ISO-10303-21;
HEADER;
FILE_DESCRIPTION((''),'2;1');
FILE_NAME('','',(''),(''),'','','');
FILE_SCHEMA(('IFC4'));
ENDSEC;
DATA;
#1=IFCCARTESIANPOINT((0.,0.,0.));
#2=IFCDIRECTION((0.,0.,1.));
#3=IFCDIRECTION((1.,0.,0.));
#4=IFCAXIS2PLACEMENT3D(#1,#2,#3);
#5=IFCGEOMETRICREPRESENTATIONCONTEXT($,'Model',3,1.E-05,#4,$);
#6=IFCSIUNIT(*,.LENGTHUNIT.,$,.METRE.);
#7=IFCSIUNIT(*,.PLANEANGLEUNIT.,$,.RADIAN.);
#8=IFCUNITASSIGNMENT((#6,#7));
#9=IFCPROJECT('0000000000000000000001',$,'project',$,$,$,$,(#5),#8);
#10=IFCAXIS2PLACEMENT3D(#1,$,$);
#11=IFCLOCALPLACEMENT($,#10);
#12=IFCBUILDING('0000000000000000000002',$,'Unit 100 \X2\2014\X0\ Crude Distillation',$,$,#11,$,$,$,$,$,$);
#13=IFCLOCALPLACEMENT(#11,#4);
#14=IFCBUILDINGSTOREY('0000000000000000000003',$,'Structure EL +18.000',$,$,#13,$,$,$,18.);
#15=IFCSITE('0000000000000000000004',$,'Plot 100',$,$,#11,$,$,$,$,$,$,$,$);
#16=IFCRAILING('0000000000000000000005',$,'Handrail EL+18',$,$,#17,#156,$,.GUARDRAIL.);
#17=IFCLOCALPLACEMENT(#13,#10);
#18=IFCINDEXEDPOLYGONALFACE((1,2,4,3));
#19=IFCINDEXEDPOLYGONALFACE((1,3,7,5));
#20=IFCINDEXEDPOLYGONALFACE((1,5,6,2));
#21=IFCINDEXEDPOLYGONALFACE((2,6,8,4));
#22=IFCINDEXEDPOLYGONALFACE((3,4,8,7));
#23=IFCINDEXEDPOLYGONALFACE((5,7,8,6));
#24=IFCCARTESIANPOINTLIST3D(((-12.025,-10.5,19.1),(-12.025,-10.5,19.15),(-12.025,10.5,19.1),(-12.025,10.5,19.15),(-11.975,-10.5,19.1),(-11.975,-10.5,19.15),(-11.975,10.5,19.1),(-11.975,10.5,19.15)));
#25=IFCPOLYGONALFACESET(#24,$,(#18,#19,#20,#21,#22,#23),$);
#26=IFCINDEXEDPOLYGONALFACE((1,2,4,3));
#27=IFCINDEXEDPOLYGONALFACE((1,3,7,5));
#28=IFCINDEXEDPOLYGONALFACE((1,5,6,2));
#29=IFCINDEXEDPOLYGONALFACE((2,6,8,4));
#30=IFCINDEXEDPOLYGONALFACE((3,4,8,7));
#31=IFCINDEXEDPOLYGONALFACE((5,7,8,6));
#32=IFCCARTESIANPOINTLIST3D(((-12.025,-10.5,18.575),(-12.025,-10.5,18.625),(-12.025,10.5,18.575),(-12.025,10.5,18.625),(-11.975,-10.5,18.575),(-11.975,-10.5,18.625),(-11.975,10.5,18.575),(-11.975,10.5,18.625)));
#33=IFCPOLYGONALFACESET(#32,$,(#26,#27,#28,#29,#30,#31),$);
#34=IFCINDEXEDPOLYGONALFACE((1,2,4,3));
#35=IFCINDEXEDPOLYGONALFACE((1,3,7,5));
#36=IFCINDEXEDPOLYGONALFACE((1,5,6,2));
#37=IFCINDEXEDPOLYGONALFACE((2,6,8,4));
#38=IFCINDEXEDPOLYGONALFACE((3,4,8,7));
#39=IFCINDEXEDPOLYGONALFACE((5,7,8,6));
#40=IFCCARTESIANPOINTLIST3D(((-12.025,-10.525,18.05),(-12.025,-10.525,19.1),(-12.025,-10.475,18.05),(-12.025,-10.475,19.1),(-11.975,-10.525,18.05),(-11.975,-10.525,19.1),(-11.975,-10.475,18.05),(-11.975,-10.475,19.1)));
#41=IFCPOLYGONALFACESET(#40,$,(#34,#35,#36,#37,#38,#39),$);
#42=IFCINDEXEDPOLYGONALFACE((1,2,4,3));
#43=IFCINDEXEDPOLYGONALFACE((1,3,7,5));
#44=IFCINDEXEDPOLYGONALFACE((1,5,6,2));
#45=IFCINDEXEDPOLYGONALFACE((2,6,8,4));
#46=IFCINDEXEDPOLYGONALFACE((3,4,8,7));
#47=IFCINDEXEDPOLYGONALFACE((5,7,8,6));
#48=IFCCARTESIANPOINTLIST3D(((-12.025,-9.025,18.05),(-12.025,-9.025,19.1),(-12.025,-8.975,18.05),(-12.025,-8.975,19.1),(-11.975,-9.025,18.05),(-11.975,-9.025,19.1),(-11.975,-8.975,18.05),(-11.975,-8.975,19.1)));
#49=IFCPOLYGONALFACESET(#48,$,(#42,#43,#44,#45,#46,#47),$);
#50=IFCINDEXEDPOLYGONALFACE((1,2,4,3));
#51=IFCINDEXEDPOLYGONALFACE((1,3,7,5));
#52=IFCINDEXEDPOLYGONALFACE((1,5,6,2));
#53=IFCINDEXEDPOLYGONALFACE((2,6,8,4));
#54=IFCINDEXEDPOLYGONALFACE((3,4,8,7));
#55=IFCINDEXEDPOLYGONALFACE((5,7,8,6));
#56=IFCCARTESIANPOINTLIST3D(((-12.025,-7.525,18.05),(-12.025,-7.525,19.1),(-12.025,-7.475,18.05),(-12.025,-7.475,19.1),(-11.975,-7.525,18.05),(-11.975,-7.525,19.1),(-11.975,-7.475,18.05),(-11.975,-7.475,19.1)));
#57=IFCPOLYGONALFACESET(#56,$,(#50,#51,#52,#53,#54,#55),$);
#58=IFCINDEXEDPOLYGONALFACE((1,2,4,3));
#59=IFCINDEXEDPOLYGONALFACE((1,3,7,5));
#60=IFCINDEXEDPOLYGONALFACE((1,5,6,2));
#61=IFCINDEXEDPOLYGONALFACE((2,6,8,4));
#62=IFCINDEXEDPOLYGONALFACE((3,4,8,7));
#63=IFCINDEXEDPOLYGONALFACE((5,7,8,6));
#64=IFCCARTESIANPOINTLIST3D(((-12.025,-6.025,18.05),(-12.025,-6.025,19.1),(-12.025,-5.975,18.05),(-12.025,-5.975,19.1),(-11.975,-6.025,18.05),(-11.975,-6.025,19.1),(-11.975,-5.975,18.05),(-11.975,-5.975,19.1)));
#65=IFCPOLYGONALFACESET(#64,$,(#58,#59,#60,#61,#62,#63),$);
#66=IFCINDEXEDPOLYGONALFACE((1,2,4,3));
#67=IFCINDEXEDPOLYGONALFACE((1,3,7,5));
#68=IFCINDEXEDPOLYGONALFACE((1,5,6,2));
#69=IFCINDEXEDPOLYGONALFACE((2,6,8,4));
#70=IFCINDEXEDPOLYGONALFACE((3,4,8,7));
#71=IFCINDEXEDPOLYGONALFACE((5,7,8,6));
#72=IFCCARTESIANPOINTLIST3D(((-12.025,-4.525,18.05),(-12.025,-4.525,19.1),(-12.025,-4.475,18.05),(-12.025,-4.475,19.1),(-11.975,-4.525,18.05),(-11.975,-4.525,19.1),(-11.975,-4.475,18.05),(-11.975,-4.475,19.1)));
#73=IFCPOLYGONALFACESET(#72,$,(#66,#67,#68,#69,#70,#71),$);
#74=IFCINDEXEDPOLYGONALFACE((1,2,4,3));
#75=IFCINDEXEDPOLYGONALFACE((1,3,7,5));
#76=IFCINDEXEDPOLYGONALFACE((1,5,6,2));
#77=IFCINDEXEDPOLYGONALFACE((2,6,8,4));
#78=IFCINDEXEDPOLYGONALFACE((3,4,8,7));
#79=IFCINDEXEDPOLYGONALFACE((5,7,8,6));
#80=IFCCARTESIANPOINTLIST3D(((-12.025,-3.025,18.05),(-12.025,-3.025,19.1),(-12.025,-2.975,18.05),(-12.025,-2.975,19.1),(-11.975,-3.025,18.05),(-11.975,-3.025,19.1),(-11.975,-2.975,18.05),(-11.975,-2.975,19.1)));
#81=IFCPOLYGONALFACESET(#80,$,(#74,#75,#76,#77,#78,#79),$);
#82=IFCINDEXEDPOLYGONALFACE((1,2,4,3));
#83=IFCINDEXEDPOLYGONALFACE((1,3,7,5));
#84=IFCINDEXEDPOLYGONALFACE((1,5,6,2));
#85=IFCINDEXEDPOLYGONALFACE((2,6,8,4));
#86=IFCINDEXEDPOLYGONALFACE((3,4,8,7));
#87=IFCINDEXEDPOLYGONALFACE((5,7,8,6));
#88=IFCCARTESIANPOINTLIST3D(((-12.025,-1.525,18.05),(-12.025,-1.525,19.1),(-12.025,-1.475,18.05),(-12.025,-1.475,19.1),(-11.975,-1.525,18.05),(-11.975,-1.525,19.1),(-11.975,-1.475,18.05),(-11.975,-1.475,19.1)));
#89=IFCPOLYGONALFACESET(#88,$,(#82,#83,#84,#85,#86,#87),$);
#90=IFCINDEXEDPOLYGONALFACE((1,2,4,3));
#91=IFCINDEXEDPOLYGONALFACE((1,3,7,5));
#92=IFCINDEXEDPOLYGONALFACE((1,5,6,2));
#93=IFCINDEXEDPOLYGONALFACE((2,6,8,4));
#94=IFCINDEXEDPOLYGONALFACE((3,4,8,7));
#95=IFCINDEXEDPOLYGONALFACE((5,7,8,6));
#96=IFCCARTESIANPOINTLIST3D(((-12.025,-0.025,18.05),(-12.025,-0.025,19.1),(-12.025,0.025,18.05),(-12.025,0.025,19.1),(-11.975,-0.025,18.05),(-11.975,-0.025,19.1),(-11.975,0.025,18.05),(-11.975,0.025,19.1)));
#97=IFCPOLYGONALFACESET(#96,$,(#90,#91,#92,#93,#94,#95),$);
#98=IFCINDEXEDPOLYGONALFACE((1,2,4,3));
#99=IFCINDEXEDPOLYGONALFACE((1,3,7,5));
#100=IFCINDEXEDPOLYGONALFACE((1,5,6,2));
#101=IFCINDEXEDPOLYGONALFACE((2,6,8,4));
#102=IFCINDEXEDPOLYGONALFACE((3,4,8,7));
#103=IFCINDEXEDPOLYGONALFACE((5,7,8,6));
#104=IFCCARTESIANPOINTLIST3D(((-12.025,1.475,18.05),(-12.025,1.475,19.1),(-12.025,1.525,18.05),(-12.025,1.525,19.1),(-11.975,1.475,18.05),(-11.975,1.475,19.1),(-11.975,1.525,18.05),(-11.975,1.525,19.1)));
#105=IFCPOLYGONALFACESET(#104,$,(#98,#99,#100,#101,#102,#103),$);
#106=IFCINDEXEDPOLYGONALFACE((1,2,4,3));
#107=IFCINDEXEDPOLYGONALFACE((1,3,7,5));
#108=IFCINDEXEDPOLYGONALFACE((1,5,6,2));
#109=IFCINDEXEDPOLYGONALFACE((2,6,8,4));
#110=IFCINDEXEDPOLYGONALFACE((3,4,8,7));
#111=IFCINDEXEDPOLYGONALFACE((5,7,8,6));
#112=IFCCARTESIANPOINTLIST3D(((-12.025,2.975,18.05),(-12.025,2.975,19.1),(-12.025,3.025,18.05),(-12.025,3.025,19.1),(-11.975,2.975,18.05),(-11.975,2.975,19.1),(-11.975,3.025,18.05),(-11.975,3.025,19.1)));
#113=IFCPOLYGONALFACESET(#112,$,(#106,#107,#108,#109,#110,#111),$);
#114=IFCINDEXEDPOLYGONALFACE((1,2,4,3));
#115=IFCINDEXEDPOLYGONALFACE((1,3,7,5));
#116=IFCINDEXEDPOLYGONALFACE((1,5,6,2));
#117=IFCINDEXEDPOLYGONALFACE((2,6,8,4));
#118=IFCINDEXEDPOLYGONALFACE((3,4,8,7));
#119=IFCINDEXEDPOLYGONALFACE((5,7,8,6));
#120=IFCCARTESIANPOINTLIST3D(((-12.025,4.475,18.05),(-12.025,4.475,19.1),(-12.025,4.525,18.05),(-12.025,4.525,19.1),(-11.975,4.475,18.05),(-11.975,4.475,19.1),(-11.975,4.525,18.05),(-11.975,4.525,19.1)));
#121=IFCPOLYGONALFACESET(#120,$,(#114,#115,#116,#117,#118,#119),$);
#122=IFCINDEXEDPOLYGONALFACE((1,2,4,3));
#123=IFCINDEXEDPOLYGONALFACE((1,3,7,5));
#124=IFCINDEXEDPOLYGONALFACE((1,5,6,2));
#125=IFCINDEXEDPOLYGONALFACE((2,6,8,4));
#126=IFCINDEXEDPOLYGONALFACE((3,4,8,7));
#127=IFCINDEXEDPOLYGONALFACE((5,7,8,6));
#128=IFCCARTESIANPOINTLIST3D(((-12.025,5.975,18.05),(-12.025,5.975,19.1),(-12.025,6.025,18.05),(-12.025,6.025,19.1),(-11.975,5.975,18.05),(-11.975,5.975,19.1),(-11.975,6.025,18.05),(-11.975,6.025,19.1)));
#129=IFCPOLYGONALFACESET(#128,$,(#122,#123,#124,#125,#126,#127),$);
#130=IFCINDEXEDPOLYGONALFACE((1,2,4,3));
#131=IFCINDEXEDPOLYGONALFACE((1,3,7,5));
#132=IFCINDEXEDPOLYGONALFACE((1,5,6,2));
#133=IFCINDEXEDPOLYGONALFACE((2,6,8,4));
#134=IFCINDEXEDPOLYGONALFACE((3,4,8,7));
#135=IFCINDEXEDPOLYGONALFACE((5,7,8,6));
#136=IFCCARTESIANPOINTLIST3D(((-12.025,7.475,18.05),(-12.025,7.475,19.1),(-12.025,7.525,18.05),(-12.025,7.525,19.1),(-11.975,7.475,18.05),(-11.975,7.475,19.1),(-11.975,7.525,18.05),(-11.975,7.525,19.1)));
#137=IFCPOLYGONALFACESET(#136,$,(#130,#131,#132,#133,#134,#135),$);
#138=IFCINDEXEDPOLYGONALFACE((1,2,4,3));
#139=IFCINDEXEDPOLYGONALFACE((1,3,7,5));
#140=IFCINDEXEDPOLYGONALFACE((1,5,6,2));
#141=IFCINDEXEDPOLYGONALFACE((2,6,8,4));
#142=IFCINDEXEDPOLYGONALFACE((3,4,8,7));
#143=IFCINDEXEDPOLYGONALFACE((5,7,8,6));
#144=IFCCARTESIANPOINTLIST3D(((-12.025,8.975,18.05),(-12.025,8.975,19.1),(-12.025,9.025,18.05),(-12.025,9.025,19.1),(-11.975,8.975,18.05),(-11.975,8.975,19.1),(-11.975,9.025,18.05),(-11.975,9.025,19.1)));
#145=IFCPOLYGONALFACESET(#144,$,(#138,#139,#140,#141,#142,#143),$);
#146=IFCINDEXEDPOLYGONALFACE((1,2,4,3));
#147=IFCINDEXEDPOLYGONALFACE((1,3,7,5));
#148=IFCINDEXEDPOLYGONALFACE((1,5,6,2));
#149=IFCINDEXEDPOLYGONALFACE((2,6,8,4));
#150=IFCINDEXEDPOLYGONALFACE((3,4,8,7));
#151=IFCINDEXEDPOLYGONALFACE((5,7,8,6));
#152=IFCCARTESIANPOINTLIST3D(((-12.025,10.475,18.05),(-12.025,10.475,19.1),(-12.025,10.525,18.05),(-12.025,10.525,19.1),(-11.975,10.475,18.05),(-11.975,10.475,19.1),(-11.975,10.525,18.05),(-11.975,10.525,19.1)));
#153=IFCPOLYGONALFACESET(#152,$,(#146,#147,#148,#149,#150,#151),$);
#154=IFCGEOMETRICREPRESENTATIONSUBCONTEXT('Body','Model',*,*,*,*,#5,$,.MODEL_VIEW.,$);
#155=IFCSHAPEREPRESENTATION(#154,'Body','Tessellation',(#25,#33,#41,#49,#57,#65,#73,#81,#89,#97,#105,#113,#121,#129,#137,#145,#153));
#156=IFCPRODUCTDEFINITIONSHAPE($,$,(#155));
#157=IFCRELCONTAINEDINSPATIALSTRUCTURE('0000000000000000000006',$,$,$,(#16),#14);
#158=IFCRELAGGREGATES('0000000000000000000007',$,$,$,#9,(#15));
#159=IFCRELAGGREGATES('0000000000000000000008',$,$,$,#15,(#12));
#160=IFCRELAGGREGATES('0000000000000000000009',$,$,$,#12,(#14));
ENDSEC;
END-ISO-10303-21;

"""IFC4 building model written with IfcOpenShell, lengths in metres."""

from ifc_helpers import new_model, si_unit, frame, origin, origin_with_axes, origin_2d, place, context, subcontext, project, spatial, rectangle, extrude, element, save


model = new_model("IFC4")

# Units and contexts
model_context = context("Model", 3, precision=1e-05, world=origin_with_axes())
body_context = subcontext(model_context, "Body", "Model", "MODEL_VIEW")
ifc_project = project(units=[si_unit("LENGTHUNIT", "METRE"), si_unit("PLANEANGLEUNIT", "RADIAN")], contexts=[model_context])

# Site, building, storey
placement = place(None, origin())
site = spatial("IfcSite", under=ifc_project, at=placement, Name="Plot 100")
building = spatial("IfcBuilding", under=site, at=placement, Name="Unit 100 — Crude Distillation")
storey_placement = place(placement, origin_with_axes())
storey = spatial("IfcBuildingStorey", under=building, at=storey_placement, Name="Structure EL +18.000", Elevation=18.0)

# Railing
railing_1_placement = place(storey_placement, origin_with_axes())
element("IfcRailing", 1, at=railing_1_placement, inside=storey, Name="Handrail EL+18", PredefinedType="GUARDRAIL", context=body_context, shape_type="SweptSolid", body=[
    extrude(rectangle(XDim=0.05, YDim=0.05, at=origin_2d()), frame((-12.0, -10.5, 19.125), z_axis=(0.0, 1.0, 0.0), x_axis=(-1.0, 0.0, 0.0)), (0.0, 0.0, 1.0), 21.0),
    extrude(rectangle(XDim=0.05, YDim=0.05, at=origin_2d()), frame((-12.0, -10.5, 18.6), z_axis=(0.0, 1.0, 0.0), x_axis=(-1.0, 0.0, 0.0)), (0.0, 0.0, 1.0), 21.0),
    extrude(rectangle(XDim=0.05, YDim=0.05, at=origin_2d()), frame((-12.0, -10.5, 18.05), z_axis=(0.0, 0.0, 1.0), x_axis=(1.0, 0.0, 0.0)), (0.0, 0.0, 1.0), 1.05),
    extrude(rectangle(XDim=0.05, YDim=0.05, at=origin_2d()), frame((-12.0, -9.0, 18.05), z_axis=(0.0, 0.0, 1.0), x_axis=(1.0, 0.0, 0.0)), (0.0, 0.0, 1.0), 1.05),
    extrude(rectangle(XDim=0.05, YDim=0.05, at=origin_2d()), frame((-12.0, -7.5, 18.05), z_axis=(0.0, 0.0, 1.0), x_axis=(1.0, 0.0, 0.0)), (0.0, 0.0, 1.0), 1.05),
    extrude(rectangle(XDim=0.05, YDim=0.05, at=origin_2d()), frame((-12.0, -6.0, 18.05), z_axis=(0.0, 0.0, 1.0), x_axis=(1.0, 0.0, 0.0)), (0.0, 0.0, 1.0), 1.05),
    extrude(rectangle(XDim=0.05, YDim=0.05, at=origin_2d()), frame((-12.0, -4.5, 18.05), z_axis=(0.0, 0.0, 1.0), x_axis=(1.0, 0.0, 0.0)), (0.0, 0.0, 1.0), 1.05),
    extrude(rectangle(XDim=0.05, YDim=0.05, at=origin_2d()), frame((-12.0, -3.0, 18.05), z_axis=(0.0, 0.0, 1.0), x_axis=(1.0, 0.0, 0.0)), (0.0, 0.0, 1.0), 1.05),
    extrude(rectangle(XDim=0.05, YDim=0.05, at=origin_2d()), frame((-12.0, -1.5, 18.05), z_axis=(0.0, 0.0, 1.0), x_axis=(1.0, 0.0, 0.0)), (0.0, 0.0, 1.0), 1.05),
    extrude(rectangle(XDim=0.05, YDim=0.05, at=origin_2d()), frame((-12.0, 0.0, 18.05), z_axis=(0.0, 0.0, 1.0), x_axis=(1.0, 0.0, 0.0)), (0.0, 0.0, 1.0), 1.05),
    extrude(rectangle(XDim=0.05, YDim=0.05, at=origin_2d()), frame((-12.0, 1.5, 18.05), z_axis=(0.0, 0.0, 1.0), x_axis=(1.0, 0.0, 0.0)), (0.0, 0.0, 1.0), 1.05),
    extrude(rectangle(XDim=0.05, YDim=0.05, at=origin_2d()), frame((-12.0, 3.0, 18.05), z_axis=(0.0, 0.0, 1.0), x_axis=(1.0, 0.0, 0.0)), (0.0, 0.0, 1.0), 1.05),
    extrude(rectangle(XDim=0.05, YDim=0.05, at=origin_2d()), frame((-12.0, 4.5, 18.05), z_axis=(0.0, 0.0, 1.0), x_axis=(1.0, 0.0, 0.0)), (0.0, 0.0, 1.0), 1.05),
    extrude(rectangle(XDim=0.05, YDim=0.05, at=origin_2d()), frame((-12.0, 6.0, 18.05), z_axis=(0.0, 0.0, 1.0), x_axis=(1.0, 0.0, 0.0)), (0.0, 0.0, 1.0), 1.05),
    extrude(rectangle(XDim=0.05, YDim=0.05, at=origin_2d()), frame((-12.0, 7.5, 18.05), z_axis=(0.0, 0.0, 1.0), x_axis=(1.0, 0.0, 0.0)), (0.0, 0.0, 1.0), 1.05),
    extrude(rectangle(XDim=0.05, YDim=0.05, at=origin_2d()), frame((-12.0, 9.0, 18.05), z_axis=(0.0, 0.0, 1.0), x_axis=(1.0, 0.0, 0.0)), (0.0, 0.0, 1.0), 1.05),
    extrude(rectangle(XDim=0.05, YDim=0.05, at=origin_2d()), frame((-12.0, 10.5, 18.05), z_axis=(0.0, 0.0, 1.0), x_axis=(1.0, 0.0, 0.0)), (0.0, 0.0, 1.0), 1.05),
])

save(model, "model.ifc")
